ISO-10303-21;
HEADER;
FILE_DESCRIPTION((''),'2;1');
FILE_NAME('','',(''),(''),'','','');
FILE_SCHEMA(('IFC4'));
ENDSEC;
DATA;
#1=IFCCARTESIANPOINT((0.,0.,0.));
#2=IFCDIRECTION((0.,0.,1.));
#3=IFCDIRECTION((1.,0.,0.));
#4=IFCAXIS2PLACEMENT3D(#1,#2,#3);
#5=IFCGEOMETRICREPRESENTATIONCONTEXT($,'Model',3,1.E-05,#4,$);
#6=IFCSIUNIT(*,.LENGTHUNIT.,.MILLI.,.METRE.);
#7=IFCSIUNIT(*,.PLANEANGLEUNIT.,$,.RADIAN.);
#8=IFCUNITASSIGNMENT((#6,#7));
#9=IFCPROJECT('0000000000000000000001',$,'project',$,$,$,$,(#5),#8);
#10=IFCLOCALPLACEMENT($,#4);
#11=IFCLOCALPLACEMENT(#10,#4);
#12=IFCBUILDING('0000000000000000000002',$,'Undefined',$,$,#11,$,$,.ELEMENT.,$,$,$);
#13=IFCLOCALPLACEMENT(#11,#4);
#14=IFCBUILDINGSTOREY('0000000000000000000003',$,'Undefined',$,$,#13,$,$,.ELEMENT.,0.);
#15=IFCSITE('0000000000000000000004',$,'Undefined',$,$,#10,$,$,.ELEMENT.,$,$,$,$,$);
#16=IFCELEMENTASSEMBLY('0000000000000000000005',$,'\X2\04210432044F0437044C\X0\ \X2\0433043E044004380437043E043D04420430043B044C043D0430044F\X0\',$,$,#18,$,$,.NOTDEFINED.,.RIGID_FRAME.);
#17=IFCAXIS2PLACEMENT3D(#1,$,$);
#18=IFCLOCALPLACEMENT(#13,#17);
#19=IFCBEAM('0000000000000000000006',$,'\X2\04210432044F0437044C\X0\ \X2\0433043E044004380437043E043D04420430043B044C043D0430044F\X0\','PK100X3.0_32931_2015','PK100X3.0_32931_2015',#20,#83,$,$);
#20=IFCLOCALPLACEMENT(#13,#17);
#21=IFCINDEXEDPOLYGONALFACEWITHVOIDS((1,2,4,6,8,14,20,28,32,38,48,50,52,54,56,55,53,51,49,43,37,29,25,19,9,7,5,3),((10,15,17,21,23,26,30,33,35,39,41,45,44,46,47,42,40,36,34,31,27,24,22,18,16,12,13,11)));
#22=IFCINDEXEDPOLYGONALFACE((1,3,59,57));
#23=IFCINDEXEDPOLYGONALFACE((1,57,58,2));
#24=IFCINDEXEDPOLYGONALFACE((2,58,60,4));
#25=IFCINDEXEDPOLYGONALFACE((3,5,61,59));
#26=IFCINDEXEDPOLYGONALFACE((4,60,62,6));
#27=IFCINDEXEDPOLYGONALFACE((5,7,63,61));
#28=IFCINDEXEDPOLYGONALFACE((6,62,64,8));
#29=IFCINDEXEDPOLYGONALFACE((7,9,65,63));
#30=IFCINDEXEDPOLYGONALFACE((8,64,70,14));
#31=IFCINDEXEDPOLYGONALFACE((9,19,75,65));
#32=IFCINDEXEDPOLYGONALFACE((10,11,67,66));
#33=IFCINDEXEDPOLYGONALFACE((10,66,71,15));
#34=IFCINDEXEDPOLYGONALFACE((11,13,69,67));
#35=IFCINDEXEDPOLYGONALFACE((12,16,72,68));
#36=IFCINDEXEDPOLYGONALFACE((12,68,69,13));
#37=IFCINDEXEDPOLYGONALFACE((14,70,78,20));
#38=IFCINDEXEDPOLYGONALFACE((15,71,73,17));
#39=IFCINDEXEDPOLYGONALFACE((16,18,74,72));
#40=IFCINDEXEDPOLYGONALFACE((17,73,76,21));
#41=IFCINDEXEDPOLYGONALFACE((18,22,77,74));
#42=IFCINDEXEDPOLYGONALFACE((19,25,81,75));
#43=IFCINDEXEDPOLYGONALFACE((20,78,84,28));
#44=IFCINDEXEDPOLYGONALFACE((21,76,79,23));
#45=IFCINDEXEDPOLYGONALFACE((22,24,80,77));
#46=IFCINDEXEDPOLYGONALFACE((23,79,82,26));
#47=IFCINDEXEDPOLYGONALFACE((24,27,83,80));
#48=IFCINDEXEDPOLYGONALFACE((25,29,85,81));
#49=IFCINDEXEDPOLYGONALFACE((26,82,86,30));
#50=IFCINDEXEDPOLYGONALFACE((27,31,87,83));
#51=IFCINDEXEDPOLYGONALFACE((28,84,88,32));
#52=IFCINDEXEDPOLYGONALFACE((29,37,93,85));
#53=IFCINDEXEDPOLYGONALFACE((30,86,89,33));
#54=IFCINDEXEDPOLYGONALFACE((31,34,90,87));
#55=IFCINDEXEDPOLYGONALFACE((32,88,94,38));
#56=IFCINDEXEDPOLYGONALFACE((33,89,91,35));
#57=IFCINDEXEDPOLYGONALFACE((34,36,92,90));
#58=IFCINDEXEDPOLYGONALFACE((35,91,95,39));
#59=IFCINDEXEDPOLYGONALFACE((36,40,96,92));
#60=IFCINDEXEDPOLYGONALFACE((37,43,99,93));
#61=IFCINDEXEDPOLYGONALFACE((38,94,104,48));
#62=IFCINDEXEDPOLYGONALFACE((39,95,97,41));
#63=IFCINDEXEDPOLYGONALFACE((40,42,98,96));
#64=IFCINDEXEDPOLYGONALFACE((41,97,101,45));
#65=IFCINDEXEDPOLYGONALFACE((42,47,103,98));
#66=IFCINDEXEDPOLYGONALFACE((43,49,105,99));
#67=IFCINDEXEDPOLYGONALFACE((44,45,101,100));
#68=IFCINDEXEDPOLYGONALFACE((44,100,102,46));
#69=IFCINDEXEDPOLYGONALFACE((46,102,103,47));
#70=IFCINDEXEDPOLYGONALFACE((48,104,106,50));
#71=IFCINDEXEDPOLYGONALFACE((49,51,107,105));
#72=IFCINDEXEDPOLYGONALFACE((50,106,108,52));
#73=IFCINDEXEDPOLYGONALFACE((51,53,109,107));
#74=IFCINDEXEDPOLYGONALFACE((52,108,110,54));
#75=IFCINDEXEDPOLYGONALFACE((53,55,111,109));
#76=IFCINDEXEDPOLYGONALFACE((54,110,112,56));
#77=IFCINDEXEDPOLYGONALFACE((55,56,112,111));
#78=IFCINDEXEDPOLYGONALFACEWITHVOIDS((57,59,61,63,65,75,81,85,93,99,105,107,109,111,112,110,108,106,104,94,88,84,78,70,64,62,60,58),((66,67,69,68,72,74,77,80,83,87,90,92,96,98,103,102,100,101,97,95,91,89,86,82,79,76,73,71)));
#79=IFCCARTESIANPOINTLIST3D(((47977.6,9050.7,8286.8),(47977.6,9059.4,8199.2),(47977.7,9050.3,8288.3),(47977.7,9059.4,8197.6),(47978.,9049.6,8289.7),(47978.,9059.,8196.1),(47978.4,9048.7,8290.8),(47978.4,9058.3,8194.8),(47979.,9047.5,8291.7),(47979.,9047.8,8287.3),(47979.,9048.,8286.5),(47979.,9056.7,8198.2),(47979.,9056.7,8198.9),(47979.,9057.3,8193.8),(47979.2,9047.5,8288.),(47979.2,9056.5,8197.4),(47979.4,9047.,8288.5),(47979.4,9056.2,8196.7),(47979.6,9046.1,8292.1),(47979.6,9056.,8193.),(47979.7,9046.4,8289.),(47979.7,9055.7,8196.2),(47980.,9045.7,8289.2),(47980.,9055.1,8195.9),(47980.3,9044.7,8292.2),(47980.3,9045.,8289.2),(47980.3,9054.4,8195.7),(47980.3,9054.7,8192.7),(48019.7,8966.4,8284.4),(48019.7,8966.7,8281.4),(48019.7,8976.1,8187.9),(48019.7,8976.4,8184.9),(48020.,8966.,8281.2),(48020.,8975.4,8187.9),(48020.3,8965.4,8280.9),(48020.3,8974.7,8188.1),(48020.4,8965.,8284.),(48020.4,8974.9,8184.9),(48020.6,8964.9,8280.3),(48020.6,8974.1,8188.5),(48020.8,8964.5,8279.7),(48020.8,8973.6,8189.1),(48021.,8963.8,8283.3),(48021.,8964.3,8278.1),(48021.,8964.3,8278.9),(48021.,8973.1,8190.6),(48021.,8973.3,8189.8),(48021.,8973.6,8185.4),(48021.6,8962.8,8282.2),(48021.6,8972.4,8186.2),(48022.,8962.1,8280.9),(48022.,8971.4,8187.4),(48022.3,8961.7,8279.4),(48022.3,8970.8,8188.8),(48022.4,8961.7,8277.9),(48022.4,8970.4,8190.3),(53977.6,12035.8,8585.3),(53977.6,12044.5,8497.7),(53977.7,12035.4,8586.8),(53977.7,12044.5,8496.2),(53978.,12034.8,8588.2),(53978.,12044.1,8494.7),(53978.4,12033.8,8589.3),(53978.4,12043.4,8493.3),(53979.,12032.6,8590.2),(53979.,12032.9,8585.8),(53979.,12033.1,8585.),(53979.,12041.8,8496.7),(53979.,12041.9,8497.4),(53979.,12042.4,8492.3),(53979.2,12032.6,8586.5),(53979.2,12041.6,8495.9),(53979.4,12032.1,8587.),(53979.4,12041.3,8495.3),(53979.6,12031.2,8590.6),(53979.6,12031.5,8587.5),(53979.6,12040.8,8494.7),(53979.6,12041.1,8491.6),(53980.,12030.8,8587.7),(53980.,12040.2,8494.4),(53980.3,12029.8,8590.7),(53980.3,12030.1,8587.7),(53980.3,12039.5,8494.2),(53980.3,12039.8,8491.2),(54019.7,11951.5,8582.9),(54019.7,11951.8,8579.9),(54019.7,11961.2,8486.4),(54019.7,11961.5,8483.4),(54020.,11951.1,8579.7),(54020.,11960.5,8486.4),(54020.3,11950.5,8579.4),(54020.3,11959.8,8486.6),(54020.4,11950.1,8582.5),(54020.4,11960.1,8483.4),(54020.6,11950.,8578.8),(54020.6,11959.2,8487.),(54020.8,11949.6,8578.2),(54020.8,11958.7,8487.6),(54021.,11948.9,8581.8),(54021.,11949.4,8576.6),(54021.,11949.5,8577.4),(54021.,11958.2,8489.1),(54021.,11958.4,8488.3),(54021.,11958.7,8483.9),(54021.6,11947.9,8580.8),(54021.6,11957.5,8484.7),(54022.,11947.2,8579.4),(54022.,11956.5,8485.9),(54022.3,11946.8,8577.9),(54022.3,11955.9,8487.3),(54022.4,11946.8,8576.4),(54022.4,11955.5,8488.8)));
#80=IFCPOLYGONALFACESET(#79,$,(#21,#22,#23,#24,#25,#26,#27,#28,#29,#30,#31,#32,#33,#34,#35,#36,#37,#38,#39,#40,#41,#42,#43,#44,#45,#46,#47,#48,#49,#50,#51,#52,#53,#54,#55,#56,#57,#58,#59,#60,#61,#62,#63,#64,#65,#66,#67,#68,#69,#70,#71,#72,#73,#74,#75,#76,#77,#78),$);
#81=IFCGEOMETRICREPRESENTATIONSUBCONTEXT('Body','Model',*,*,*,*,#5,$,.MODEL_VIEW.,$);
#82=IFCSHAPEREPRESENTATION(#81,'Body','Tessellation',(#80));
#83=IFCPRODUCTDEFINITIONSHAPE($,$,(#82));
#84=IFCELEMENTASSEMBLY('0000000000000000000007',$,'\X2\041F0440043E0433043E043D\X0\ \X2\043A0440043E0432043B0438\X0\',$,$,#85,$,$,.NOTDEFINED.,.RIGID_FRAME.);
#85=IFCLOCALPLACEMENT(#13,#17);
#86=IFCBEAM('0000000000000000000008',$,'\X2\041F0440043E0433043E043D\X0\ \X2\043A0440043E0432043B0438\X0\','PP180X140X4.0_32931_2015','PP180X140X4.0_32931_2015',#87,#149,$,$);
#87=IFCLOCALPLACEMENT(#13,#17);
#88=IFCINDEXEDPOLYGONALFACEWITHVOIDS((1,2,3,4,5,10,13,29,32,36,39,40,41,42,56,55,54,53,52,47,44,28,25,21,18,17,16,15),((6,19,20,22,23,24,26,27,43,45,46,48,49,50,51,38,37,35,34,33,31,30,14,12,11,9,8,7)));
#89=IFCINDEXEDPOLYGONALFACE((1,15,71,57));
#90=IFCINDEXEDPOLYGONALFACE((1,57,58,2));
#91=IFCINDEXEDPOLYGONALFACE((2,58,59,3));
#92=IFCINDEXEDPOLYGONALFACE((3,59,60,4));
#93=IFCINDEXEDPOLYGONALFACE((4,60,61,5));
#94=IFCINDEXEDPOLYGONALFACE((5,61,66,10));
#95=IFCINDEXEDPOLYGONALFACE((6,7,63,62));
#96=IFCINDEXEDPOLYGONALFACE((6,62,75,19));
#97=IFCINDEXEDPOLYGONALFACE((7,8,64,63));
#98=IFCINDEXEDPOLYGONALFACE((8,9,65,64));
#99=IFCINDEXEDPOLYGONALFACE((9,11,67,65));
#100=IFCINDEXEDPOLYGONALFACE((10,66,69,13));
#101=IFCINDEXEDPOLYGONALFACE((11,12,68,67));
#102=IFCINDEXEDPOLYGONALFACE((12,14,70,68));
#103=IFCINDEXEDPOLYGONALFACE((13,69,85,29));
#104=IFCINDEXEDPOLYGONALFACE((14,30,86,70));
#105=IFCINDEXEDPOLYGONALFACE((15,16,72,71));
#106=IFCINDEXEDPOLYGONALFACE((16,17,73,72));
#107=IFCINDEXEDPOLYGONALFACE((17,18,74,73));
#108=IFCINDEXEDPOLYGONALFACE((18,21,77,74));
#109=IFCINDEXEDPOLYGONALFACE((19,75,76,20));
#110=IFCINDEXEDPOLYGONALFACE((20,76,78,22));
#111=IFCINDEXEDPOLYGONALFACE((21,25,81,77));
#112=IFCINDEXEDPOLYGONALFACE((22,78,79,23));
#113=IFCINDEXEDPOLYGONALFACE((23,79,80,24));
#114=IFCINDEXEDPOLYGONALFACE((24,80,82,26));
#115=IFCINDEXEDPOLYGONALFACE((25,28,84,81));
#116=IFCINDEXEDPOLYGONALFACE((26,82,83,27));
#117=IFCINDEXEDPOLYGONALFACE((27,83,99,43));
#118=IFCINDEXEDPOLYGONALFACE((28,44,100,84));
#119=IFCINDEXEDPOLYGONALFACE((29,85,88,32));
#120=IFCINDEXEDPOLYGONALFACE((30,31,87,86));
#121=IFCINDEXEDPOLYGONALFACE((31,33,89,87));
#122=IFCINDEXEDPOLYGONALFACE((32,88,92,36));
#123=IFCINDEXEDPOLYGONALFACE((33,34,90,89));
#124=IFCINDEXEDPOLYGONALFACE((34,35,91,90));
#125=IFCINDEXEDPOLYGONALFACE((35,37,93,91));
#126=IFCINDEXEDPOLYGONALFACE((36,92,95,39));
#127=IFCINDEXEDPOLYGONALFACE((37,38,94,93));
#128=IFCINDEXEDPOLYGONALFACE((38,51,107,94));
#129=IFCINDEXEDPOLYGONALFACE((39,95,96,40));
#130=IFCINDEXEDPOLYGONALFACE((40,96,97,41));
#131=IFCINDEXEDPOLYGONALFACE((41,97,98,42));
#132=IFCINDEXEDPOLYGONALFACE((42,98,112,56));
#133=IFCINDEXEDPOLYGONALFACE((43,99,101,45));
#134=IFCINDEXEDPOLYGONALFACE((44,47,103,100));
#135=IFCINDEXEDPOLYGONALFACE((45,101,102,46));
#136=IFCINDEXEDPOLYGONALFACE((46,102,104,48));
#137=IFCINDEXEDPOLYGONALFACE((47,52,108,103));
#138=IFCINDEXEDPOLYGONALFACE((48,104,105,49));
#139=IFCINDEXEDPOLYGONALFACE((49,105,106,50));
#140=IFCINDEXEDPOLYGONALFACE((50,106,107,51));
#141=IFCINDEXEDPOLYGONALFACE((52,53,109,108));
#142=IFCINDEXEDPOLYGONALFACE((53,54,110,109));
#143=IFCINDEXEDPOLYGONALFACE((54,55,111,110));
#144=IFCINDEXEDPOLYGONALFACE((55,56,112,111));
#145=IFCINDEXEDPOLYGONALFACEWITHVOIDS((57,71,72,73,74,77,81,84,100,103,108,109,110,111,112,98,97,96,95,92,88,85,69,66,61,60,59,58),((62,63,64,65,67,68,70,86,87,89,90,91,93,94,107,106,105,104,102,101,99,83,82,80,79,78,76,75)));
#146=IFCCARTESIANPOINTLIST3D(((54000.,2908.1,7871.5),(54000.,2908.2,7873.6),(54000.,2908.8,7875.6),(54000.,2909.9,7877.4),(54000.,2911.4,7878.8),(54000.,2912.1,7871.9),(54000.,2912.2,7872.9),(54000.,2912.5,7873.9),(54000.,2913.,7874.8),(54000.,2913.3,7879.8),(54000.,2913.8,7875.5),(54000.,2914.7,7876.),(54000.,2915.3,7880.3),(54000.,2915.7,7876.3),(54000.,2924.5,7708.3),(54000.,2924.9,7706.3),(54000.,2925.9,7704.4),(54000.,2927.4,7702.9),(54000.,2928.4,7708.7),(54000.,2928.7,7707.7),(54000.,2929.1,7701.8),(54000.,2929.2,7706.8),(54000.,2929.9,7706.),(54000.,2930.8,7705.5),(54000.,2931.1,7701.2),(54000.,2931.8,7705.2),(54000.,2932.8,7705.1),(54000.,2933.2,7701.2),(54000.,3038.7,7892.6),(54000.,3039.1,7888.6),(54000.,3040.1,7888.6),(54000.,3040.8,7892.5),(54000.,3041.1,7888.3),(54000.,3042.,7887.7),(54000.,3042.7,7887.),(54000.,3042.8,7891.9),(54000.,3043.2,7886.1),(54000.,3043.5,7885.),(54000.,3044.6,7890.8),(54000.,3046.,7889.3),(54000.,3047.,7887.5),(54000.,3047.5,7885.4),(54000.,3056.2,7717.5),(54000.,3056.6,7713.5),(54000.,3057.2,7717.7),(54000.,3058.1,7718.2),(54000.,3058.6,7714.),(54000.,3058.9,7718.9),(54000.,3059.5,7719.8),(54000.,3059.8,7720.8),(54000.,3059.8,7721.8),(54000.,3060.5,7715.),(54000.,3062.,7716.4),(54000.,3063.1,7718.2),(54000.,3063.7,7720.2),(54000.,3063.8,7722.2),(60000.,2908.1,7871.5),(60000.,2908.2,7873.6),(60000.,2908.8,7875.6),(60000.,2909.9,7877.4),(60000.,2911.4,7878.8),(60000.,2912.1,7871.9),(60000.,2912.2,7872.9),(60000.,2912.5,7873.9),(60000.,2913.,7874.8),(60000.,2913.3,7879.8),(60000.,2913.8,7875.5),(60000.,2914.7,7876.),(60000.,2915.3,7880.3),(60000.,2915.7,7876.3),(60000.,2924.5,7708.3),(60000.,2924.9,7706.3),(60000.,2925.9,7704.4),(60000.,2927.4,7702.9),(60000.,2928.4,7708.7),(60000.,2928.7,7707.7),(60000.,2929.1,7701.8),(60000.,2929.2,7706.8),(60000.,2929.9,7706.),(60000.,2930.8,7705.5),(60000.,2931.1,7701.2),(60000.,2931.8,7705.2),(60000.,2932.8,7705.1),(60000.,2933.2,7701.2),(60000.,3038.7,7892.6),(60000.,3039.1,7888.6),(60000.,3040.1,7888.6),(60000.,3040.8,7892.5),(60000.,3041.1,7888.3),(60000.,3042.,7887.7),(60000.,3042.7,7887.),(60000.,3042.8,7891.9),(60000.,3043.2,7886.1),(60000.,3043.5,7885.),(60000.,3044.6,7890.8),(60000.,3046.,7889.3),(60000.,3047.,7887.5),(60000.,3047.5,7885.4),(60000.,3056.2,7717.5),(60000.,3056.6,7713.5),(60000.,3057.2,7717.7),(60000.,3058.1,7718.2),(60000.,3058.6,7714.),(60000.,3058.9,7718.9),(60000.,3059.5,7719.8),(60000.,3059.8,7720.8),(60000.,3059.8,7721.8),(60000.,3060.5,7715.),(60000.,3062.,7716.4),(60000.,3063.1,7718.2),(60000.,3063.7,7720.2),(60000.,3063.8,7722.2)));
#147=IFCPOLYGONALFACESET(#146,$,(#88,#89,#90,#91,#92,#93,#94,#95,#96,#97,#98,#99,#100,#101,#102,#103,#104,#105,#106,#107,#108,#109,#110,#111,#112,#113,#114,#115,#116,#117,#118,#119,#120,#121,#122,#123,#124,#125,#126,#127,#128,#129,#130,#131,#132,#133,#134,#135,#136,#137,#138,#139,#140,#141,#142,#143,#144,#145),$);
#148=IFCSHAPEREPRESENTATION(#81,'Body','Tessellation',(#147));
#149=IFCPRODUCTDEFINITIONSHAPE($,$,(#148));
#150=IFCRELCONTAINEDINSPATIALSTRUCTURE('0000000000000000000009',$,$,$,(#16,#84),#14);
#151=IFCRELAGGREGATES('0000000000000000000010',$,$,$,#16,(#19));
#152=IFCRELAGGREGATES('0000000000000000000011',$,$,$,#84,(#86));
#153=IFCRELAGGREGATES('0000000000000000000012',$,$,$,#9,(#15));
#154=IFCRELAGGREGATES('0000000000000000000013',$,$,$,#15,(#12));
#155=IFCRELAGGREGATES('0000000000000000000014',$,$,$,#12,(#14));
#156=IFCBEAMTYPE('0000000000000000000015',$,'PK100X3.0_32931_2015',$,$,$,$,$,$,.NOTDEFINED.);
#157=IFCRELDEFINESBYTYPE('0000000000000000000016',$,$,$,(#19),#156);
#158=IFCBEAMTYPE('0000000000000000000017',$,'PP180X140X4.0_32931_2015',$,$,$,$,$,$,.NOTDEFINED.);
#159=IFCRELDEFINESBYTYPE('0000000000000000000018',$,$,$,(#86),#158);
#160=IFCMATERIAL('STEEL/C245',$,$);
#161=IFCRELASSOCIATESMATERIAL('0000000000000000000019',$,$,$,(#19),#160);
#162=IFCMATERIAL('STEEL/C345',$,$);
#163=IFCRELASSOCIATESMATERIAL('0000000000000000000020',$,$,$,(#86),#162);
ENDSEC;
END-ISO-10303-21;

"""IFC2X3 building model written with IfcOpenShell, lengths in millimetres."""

from ifc_helpers import new_model, si_unit, frame, origin_with_axes, origin_2d_with_axis, place, context, subcontext, project, spatial, hollow_rectangle, extrude, material, type_object, element, aggregate, save


model = new_model("IFC2X3")

# Units and contexts
model_context = context("Model", 3, precision=1e-05, world=origin_with_axes())
body_context = subcontext(model_context, "Body", "Model", "MODEL_VIEW")
ifc_project = project(units=[si_unit("LENGTHUNIT", "METRE", prefix="MILLI"), si_unit("PLANEANGLEUNIT", "RADIAN")], contexts=[model_context])

# Site, building, storey
site_placement = place(None, origin_with_axes())
site = spatial("IfcSite", under=ifc_project, at=site_placement, Name="Undefined", CompositionType="ELEMENT")
building_placement = place(site_placement, origin_with_axes())
building = spatial("IfcBuilding", under=site, at=building_placement, Name="Undefined", CompositionType="ELEMENT")
storey_placement = place(building_placement, origin_with_axes())
storey = spatial("IfcBuildingStorey", under=building, at=storey_placement, Name="Undefined", CompositionType="ELEMENT", Elevation=0.0)

# Shared definitions
ifc_material_1 = material(Name="STEEL/C345")

# Element assembly, beam
ifc_material_2 = material(Name="STEEL/C245")
beam_type_1 = type_object("IfcBeamType", Name="PK100X3.0_32931_2015", PredefinedType="NOTDEFINED")
assembly_1_placement = place(storey_placement, origin_with_axes())
assembly_1 = element("IfcElementAssembly", 1, at=assembly_1_placement, inside=storey, Name="Связь горизонтальная", AssemblyPlace="NOTDEFINED", PredefinedType="RIGID_FRAME")
beam_1_placement = place(assembly_1_placement, frame((54000.0, 11995.6, 8537.0), z_axis=(0.0, -0.099504, 0.995037), x_axis=(-0.894427, -0.444994, -0.044499)))
beam_1 = element("IfcBeam", 2, at=beam_1_placement, type_object=beam_type_1, material=ifc_material_2, Name="Связь горизонтальная", Description="PK100X3.0_32931_2015", ObjectType="PK100X3.0_32931_2015", context=body_context, shape_type="SweptSolid", body=[
    extrude(hollow_rectangle(XDim=100.0, YDim=100.0, WallThickness=3.0, InnerFilletRadius=3.0, OuterFilletRadius=6.0, at=origin_2d_with_axis()), frame((6708.2, 0.0, 0.0), z_axis=(-1.0, 0.0, 0.0), x_axis=(0.0, -1.0, 0.0)), (0.0, 0.0, 1.0), 6708.2),
])
aggregate(assembly_1, [beam_1])

# Element assembly, beam
beam_type_2 = type_object("IfcBeamType", Name="PP180X140X4.0_32931_2015", PredefinedType="NOTDEFINED")
assembly_2_placement = place(storey_placement, origin_with_axes())
assembly_2 = element("IfcElementAssembly", 3, at=assembly_2_placement, inside=storey, Name="Прогон кровли", AssemblyPlace="NOTDEFINED", PredefinedType="RIGID_FRAME")
beam_2_placement = place(assembly_2_placement, frame((54000.0, 2986.0, 7796.9), z_axis=(0.0, -0.099504, 0.995037), x_axis=(1.0, 0.0, 0.0)))
beam_2 = element("IfcBeam", 4, at=beam_2_placement, type_object=beam_type_2, material=ifc_material_1, Name="Прогон кровли", Description="PP180X140X4.0_32931_2015", ObjectType="PP180X140X4.0_32931_2015", context=body_context, shape_type="SweptSolid", body=[
    extrude(hollow_rectangle(XDim=140.0, YDim=180.0, WallThickness=4.0, InnerFilletRadius=4.0, OuterFilletRadius=8.0, at=origin_2d_with_axis()), frame((6000.0, 0.0, 0.0), z_axis=(-1.0, 0.0, 0.0), x_axis=(0.0, -1.0, 0.0)), (0.0, 0.0, 1.0), 6000.0),
])
aggregate(assembly_2, [beam_2])

save(model, "model.ifc")
